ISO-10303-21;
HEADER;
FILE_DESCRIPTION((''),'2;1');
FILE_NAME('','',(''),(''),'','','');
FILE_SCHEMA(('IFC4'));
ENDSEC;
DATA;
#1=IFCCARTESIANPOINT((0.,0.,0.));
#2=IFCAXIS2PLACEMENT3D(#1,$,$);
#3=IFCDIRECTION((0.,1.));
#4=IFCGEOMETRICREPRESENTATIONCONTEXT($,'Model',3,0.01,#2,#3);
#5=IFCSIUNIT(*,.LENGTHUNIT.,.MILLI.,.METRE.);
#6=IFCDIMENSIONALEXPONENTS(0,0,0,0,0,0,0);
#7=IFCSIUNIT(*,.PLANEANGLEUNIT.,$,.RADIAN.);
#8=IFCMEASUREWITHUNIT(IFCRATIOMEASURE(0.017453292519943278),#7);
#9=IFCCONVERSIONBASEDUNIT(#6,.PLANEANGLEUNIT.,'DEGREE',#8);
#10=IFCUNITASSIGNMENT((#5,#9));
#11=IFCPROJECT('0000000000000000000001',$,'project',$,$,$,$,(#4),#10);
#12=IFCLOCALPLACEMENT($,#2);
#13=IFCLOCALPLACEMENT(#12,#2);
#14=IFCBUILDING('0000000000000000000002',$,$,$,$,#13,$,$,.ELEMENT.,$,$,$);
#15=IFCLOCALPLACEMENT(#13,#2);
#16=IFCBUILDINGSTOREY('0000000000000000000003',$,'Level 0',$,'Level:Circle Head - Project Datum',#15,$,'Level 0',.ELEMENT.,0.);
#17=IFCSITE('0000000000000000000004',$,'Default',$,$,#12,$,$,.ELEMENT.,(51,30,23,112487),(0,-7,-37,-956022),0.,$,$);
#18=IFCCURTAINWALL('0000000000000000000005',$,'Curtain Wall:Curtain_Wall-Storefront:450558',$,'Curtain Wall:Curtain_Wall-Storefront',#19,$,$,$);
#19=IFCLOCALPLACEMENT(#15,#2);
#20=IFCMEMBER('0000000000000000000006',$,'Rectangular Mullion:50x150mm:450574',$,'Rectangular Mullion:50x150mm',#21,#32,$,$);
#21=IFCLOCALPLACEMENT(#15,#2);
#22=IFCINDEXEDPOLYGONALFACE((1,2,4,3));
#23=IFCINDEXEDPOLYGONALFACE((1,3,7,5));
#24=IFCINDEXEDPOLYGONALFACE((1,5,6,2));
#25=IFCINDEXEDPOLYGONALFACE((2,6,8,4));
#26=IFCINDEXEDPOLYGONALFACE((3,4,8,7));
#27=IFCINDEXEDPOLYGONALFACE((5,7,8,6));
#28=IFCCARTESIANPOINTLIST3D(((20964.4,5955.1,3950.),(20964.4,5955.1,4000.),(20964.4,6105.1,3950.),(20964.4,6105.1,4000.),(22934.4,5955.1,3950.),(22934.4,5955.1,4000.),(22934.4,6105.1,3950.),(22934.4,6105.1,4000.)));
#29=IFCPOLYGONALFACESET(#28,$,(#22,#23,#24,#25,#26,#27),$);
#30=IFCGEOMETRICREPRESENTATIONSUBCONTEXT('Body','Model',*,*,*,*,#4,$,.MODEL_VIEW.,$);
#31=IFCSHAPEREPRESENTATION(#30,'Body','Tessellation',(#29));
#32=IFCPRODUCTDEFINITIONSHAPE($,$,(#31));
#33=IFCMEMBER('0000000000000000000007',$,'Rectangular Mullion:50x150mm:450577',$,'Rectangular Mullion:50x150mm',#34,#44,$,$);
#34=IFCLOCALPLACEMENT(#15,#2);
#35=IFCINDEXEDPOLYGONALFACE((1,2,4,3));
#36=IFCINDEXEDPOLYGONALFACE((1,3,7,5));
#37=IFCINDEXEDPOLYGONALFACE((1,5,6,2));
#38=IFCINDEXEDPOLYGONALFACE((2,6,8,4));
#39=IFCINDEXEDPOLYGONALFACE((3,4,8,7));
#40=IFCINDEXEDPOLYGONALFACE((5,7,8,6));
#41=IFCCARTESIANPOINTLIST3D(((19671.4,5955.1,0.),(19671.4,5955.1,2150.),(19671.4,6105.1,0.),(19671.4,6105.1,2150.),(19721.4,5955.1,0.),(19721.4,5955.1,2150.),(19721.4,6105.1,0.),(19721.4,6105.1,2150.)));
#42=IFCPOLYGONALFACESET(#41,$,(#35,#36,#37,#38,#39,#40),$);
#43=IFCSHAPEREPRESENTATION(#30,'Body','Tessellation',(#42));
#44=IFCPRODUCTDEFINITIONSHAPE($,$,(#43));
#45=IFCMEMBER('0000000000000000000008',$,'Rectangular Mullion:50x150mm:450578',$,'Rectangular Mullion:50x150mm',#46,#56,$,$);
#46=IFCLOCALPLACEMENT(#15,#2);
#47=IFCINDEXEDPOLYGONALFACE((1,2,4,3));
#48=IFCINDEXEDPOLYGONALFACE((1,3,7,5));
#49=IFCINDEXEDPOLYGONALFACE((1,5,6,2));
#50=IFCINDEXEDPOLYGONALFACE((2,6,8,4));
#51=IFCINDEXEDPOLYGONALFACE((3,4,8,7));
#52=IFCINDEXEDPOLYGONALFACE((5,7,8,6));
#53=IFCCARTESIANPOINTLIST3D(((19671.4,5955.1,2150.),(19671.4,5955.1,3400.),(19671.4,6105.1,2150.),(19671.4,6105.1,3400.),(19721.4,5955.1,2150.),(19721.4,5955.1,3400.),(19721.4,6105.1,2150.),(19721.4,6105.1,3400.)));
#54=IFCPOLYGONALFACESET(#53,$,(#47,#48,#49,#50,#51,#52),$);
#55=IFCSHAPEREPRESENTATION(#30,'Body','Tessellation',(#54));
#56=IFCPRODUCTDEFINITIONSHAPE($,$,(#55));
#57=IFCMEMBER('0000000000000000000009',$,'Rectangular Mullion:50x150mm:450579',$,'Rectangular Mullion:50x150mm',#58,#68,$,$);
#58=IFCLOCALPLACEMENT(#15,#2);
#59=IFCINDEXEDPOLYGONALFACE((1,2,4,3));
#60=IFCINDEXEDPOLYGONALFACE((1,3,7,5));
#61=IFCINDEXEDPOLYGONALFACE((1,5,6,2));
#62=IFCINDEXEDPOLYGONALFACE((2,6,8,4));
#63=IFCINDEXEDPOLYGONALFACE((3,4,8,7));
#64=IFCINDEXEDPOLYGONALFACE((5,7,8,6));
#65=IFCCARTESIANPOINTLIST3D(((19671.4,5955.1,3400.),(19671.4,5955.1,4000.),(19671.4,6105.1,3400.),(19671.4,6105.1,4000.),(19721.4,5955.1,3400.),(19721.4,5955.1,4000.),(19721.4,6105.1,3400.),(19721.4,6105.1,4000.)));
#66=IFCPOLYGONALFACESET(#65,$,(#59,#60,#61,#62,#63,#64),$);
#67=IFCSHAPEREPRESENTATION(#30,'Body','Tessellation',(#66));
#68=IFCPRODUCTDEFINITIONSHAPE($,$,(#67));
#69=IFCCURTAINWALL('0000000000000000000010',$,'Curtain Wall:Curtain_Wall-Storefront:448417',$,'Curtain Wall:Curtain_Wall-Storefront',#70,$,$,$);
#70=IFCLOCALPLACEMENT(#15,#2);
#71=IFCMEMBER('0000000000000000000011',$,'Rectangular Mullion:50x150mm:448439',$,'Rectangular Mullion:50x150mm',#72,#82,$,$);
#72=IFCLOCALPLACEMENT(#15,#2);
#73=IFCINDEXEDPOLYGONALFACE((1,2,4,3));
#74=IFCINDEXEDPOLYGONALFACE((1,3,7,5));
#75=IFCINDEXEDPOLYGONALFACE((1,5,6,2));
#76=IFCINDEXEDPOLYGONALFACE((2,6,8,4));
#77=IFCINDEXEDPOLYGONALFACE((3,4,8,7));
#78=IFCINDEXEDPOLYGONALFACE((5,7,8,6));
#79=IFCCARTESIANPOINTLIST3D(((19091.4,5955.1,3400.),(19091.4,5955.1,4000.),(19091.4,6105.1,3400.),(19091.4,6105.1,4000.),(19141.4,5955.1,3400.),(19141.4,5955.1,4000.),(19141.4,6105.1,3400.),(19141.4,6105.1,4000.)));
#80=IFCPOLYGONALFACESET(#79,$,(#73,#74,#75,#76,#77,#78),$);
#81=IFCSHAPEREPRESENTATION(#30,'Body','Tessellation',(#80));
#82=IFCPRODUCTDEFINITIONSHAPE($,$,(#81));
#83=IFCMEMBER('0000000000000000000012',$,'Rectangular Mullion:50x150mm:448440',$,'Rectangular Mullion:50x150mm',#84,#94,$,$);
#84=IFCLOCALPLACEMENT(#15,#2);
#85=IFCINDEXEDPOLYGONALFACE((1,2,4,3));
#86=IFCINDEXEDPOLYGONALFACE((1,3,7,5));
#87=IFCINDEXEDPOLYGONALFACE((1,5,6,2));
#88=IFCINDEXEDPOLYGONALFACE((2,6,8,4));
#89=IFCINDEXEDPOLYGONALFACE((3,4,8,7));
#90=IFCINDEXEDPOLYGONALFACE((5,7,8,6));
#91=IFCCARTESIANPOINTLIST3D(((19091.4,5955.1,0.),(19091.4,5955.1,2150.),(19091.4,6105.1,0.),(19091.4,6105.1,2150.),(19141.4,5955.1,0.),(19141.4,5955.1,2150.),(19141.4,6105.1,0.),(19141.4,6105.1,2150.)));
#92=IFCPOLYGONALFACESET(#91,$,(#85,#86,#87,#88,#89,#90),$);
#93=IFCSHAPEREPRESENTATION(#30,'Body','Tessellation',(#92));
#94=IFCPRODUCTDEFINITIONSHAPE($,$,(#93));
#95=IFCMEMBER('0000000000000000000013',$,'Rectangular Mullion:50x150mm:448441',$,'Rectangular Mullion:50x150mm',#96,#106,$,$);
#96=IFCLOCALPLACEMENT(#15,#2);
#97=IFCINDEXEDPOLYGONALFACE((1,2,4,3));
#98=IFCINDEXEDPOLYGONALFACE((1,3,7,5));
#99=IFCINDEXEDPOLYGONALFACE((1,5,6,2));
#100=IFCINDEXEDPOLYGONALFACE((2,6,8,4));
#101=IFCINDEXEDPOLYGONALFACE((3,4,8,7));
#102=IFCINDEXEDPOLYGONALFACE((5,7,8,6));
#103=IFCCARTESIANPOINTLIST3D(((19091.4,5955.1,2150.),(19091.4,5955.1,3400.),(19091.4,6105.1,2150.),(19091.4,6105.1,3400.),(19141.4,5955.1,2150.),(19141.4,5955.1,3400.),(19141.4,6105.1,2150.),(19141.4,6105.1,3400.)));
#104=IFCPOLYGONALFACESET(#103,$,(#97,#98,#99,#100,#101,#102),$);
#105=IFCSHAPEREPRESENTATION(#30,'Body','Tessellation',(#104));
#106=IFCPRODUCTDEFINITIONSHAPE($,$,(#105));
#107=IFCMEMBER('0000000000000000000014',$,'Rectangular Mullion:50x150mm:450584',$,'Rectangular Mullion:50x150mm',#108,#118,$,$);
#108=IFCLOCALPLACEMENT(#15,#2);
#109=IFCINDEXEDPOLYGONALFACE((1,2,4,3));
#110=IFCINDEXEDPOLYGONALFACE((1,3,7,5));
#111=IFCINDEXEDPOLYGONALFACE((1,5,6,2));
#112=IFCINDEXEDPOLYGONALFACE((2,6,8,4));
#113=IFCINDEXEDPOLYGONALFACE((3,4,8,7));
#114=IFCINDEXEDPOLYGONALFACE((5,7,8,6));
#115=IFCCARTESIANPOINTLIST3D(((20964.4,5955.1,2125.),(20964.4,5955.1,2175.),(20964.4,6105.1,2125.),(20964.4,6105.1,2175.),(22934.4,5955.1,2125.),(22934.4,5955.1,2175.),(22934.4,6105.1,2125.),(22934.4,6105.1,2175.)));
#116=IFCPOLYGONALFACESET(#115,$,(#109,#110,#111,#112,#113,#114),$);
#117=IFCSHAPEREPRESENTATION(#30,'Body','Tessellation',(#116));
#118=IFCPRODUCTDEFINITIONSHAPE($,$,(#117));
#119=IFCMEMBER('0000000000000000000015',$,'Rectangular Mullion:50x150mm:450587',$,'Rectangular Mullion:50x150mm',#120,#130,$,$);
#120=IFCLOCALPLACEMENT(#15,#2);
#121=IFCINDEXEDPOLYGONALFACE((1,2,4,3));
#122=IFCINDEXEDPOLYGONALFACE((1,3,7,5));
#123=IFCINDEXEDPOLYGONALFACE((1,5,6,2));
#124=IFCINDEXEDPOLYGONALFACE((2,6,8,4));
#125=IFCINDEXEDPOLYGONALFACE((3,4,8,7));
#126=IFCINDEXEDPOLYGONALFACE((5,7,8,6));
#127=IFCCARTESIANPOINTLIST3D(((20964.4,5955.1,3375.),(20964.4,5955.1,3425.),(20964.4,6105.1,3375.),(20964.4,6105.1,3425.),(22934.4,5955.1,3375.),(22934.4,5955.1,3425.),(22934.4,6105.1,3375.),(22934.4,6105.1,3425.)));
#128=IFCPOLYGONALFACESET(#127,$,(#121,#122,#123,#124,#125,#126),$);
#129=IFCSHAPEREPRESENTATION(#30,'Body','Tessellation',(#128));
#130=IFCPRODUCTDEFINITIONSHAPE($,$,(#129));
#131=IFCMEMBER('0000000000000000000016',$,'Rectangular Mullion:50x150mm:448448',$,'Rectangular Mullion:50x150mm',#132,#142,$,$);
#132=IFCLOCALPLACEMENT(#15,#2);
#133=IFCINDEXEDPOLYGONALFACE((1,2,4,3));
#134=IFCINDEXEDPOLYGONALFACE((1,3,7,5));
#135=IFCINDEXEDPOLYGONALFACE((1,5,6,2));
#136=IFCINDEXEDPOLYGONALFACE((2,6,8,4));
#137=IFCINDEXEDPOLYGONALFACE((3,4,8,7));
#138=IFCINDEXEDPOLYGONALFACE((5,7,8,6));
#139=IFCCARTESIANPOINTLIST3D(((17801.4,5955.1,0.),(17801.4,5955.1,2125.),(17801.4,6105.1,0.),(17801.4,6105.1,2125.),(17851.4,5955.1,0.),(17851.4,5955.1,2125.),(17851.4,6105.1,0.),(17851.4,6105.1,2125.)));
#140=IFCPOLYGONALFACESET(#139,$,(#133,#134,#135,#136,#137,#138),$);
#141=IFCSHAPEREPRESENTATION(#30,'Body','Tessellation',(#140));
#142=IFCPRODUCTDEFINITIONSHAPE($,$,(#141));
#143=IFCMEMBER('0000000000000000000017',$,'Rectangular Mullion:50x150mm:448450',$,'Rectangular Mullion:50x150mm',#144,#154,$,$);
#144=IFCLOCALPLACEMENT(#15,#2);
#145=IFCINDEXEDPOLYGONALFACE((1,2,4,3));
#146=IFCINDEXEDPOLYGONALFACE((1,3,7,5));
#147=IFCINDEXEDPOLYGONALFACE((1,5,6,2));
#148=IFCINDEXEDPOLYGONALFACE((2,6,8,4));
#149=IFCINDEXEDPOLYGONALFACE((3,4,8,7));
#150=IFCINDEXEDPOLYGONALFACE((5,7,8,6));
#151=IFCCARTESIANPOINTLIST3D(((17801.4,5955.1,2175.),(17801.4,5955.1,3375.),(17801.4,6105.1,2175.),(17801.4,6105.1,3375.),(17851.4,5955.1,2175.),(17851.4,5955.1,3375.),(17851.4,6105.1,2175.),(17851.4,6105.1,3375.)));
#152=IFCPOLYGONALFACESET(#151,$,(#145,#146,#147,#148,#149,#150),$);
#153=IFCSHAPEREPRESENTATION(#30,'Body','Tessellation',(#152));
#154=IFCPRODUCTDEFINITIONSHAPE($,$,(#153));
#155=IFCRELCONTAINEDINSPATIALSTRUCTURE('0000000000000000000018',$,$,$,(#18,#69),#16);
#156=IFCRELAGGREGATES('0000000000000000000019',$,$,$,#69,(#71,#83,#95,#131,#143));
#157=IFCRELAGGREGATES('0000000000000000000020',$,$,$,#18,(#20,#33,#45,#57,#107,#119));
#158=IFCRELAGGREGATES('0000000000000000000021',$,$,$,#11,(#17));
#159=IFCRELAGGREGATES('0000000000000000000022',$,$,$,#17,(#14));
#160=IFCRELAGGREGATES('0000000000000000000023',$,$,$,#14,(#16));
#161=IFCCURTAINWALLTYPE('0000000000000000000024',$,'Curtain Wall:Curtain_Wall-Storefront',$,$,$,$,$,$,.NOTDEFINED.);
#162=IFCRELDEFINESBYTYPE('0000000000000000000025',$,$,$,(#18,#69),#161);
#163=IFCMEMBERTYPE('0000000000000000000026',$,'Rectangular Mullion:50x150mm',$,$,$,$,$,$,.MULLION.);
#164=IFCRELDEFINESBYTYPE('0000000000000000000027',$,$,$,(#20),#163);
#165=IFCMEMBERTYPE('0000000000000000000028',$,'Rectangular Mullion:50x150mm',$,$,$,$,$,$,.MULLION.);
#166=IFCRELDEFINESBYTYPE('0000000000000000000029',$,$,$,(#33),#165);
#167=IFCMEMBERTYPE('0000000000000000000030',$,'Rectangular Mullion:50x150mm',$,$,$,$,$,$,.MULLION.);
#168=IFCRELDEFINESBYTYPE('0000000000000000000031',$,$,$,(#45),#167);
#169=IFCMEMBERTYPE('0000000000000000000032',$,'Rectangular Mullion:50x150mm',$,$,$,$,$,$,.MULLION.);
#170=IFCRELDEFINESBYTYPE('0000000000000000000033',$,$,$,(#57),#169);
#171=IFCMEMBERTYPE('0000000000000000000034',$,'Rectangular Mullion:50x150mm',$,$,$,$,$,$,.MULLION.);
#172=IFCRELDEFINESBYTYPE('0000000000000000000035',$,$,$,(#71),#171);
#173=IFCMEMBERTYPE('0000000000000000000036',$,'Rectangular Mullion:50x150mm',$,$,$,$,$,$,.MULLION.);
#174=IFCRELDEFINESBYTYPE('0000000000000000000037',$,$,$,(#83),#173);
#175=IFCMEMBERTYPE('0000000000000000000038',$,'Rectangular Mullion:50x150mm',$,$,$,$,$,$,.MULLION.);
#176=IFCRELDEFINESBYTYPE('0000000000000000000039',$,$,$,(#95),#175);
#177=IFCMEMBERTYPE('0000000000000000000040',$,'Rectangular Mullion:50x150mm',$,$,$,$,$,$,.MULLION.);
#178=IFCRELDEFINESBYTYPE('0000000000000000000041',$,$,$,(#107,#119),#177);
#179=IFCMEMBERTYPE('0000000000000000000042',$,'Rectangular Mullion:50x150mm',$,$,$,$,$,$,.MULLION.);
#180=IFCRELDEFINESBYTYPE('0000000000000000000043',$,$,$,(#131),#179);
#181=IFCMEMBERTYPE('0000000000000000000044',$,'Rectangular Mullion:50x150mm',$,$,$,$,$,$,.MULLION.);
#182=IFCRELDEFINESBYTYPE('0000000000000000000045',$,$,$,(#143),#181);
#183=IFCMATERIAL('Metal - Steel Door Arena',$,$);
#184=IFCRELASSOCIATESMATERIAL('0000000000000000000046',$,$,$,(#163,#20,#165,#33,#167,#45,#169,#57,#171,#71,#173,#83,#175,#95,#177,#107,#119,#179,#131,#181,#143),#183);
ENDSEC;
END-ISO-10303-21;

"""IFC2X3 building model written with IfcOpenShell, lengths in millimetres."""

from ifc_helpers import new_model, entity, si_unit, converted_unit, direction, frame, origin, origin_2d_with_axis, place, context, subcontext, project, spatial, rectangle, extrude, source, transform, mapped, material, type_object, type_shapes, element, aggregate, save


model = new_model("IFC2X3")

# Units and contexts
model_context = context("Model", 3, precision=0.01, world=origin(), true_north=direction((0.0, 1.0)))
body_context = subcontext(model_context, "Body", "Model", "MODEL_VIEW")
ifc_project = project(units=[si_unit("LENGTHUNIT", "METRE", prefix="MILLI"), converted_unit("PLANEANGLEUNIT", "DEGREE", entity("IfcRatioMeasure", 0.017453292519943278), si_unit("PLANEANGLEUNIT", "RADIAN"), dimensions=[0, 0, 0, 0, 0, 0, 0])], contexts=[model_context])

# Site, building, storey
site_placement = place(None, origin())
site = spatial("IfcSite", under=ifc_project, at=site_placement, Name="Default", CompositionType="ELEMENT", RefLatitude=(51, 30, 23, 112487), RefLongitude=(0, -7, -37, -956022), RefElevation=0.0)
building_placement = place(site_placement, origin())
building = spatial("IfcBuilding", under=site, at=building_placement, CompositionType="ELEMENT")
storey_placement = place(building_placement, origin())
storey = spatial("IfcBuildingStorey", under=building, at=storey_placement, Name="Level 0", ObjectType="Level:Circle Head - Project Datum", LongName="Level 0", CompositionType="ELEMENT", Elevation=0.0)

# Curtain walls, members
curtain_wall_type = type_object("IfcCurtainWallType", Name="Curtain Wall:Curtain_Wall-Storefront", PredefinedType="NOTDEFINED")
curtain_wall_1_placement = place(storey_placement, origin())
curtain_wall_1 = element("IfcCurtainWall", 1, at=curtain_wall_1_placement, inside=storey, type_object=curtain_wall_type, Name="Curtain Wall:Curtain_Wall-Storefront:450558", ObjectType="Curtain Wall:Curtain_Wall-Storefront")
ifc_material_1 = material(Name="Metal - Steel Door Arena")
member_type_1 = type_object("IfcMemberType", Name="Rectangular Mullion:50x150mm", PredefinedType="MULLION", material=ifc_material_1)
shared_shape_1 = source(origin(), body_context, "Body", "SweptSolid", [
    extrude(rectangle(XDim=150.0, YDim=50.0, at=origin_2d_with_axis()), frame((-25.0, 0.0, -1970.0), z_axis=(0.0, 0.0, 1.0), x_axis=(0.0, -1.0, 0.0)), (0.0, 0.0, 1.0), 1970.0),
])
type_shapes(member_type_1, [shared_shape_1])
member_1_placement = place(curtain_wall_1_placement, frame((20964.4, 6030.1, 4000.0), z_axis=(-1.0, 0.0, 0.0), x_axis=(0.0, 0.0, 1.0)))
member_1 = element("IfcMember", 2, at=member_1_placement, type_object=member_type_1, material=ifc_material_1, Name="Rectangular Mullion:50x150mm:450574", ObjectType="Rectangular Mullion:50x150mm", context=body_context, shape_type="MappedRepresentation", body=[
    mapped(shared_shape_1, transform((0.0, 0.0, 0.0), scale=1.0)),
])
member_type_2 = type_object("IfcMemberType", Name="Rectangular Mullion:50x150mm", PredefinedType="MULLION", material=ifc_material_1)
shared_shape_2 = source(origin(), body_context, "Body", "SweptSolid", [
    extrude(rectangle(XDim=150.0, YDim=50.0, at=origin_2d_with_axis()), frame((-25.0, 0.0, -2150.0), z_axis=(0.0, 0.0, 1.0), x_axis=(0.0, -1.0, 0.0)), (0.0, 0.0, 1.0), 2150.0),
])
type_shapes(member_type_2, [shared_shape_2])
member_2_placement = place(curtain_wall_1_placement, frame((19671.4, 6030.1, 0.0), z_axis=(0.0, 0.0, -1.0), x_axis=(-1.0, 0.0, 0.0)))
member_2 = element("IfcMember", 3, at=member_2_placement, type_object=member_type_2, material=ifc_material_1, Name="Rectangular Mullion:50x150mm:450577", ObjectType="Rectangular Mullion:50x150mm", context=body_context, shape_type="MappedRepresentation", body=[
    mapped(shared_shape_2, transform((0.0, 0.0, 0.0), scale=1.0)),
])
member_type_3 = type_object("IfcMemberType", Name="Rectangular Mullion:50x150mm", PredefinedType="MULLION", material=ifc_material_1)
shared_shape_3 = source(origin(), body_context, "Body", "SweptSolid", [
    extrude(rectangle(XDim=150.0, YDim=50.0, at=origin_2d_with_axis()), frame((-25.0, 0.0, -1250.0), z_axis=(0.0, 0.0, 1.0), x_axis=(0.0, -1.0, 0.0)), (0.0, 0.0, 1.0), 1250.0),
])
type_shapes(member_type_3, [shared_shape_3])
member_3_placement = place(curtain_wall_1_placement, frame((19671.4, 6030.1, 2150.0), z_axis=(0.0, 0.0, -1.0), x_axis=(-1.0, 0.0, 0.0)))
member_3 = element("IfcMember", 4, at=member_3_placement, type_object=member_type_3, material=ifc_material_1, Name="Rectangular Mullion:50x150mm:450578", ObjectType="Rectangular Mullion:50x150mm", context=body_context, shape_type="MappedRepresentation", body=[
    mapped(shared_shape_3, transform((0.0, 0.0, 0.0), scale=1.0)),
])
member_type_4 = type_object("IfcMemberType", Name="Rectangular Mullion:50x150mm", PredefinedType="MULLION", material=ifc_material_1)
shared_shape_4 = source(origin(), body_context, "Body", "SweptSolid", [
    extrude(rectangle(XDim=150.0, YDim=50.0, at=origin_2d_with_axis()), frame((-25.0, 0.0, -600.0), z_axis=(0.0, 0.0, 1.0), x_axis=(0.0, -1.0, 0.0)), (0.0, 0.0, 1.0), 600.0),
])
type_shapes(member_type_4, [shared_shape_4])
member_4_placement = place(curtain_wall_1_placement, frame((19671.4, 6030.1, 3400.0), z_axis=(0.0, 0.0, -1.0), x_axis=(-1.0, 0.0, 0.0)))
member_4 = element("IfcMember", 5, at=member_4_placement, type_object=member_type_4, material=ifc_material_1, Name="Rectangular Mullion:50x150mm:450579", ObjectType="Rectangular Mullion:50x150mm", context=body_context, shape_type="MappedRepresentation", body=[
    mapped(shared_shape_4, transform((0.0, 0.0, 0.0), scale=1.0)),
])
curtain_wall_2_placement = place(storey_placement, origin())
curtain_wall_2 = element("IfcCurtainWall", 6, at=curtain_wall_2_placement, inside=storey, type_object=curtain_wall_type, Name="Curtain Wall:Curtain_Wall-Storefront:448417", ObjectType="Curtain Wall:Curtain_Wall-Storefront")
member_type_5 = type_object("IfcMemberType", Name="Rectangular Mullion:50x150mm", PredefinedType="MULLION", material=ifc_material_1)
shared_shape_5 = source(origin(), body_context, "Body", "SweptSolid", [
    extrude(rectangle(XDim=150.0, YDim=50.0, at=origin_2d_with_axis()), frame((-25.0, 0.0, -600.0), z_axis=(0.0, 0.0, 1.0), x_axis=(0.0, -1.0, 0.0)), (0.0, 0.0, 1.0), 600.0),
])
type_shapes(member_type_5, [shared_shape_5])
member_5_placement = place(curtain_wall_2_placement, frame((19141.4, 6030.1, 4000.0)))
member_5 = element("IfcMember", 7, at=member_5_placement, type_object=member_type_5, material=ifc_material_1, Name="Rectangular Mullion:50x150mm:448439", ObjectType="Rectangular Mullion:50x150mm", context=body_context, shape_type="MappedRepresentation", body=[
    mapped(shared_shape_5, transform((0.0, 0.0, 0.0), scale=1.0)),
])
member_type_6 = type_object("IfcMemberType", Name="Rectangular Mullion:50x150mm", PredefinedType="MULLION", material=ifc_material_1)
shared_shape_6 = source(origin(), body_context, "Body", "SweptSolid", [
    extrude(rectangle(XDim=150.0, YDim=50.0, at=origin_2d_with_axis()), frame((-25.0, 0.0, -2150.0), z_axis=(0.0, 0.0, 1.0), x_axis=(0.0, -1.0, 0.0)), (0.0, 0.0, 1.0), 2150.0),
])
type_shapes(member_type_6, [shared_shape_6])
member_6_placement = place(curtain_wall_2_placement, frame((19141.4, 6030.1, 2150.0)))
member_6 = element("IfcMember", 8, at=member_6_placement, type_object=member_type_6, material=ifc_material_1, Name="Rectangular Mullion:50x150mm:448440", ObjectType="Rectangular Mullion:50x150mm", context=body_context, shape_type="MappedRepresentation", body=[
    mapped(shared_shape_6, transform((0.0, 0.0, 0.0), scale=1.0)),
])
member_type_7 = type_object("IfcMemberType", Name="Rectangular Mullion:50x150mm", PredefinedType="MULLION", material=ifc_material_1)
shared_shape_7 = source(origin(), body_context, "Body", "SweptSolid", [
    extrude(rectangle(XDim=150.0, YDim=50.0, at=origin_2d_with_axis()), frame((-25.0, 0.0, -1250.0), z_axis=(0.0, 0.0, 1.0), x_axis=(0.0, -1.0, 0.0)), (0.0, 0.0, 1.0), 1250.0),
])
type_shapes(member_type_7, [shared_shape_7])
member_7_placement = place(curtain_wall_2_placement, frame((19141.4, 6030.1, 3400.0)))
member_7 = element("IfcMember", 9, at=member_7_placement, type_object=member_type_7, material=ifc_material_1, Name="Rectangular Mullion:50x150mm:448441", ObjectType="Rectangular Mullion:50x150mm", context=body_context, shape_type="MappedRepresentation", body=[
    mapped(shared_shape_7, transform((0.0, 0.0, 0.0), scale=1.0)),
])

# Members
member_type_8 = type_object("IfcMemberType", Name="Rectangular Mullion:50x150mm", PredefinedType="MULLION", material=ifc_material_1)
shared_shape_8 = source(origin(), body_context, "Body", "SweptSolid", [
    extrude(rectangle(XDim=150.0, YDim=50.0, at=origin_2d_with_axis()), frame((0.0, 0.0, -1970.0), z_axis=(0.0, 0.0, 1.0), x_axis=(0.0, -1.0, 0.0)), (0.0, 0.0, 1.0), 1970.0),
])
type_shapes(member_type_8, [shared_shape_8])
member_8_placement = place(curtain_wall_1_placement, frame((20964.4, 6030.1, 2150.0), z_axis=(-1.0, 0.0, 0.0), x_axis=(0.0, 0.0, 1.0)))
member_8 = element("IfcMember", 10, at=member_8_placement, type_object=member_type_8, material=ifc_material_1, Name="Rectangular Mullion:50x150mm:450584", ObjectType="Rectangular Mullion:50x150mm", context=body_context, shape_type="MappedRepresentation", body=[
    mapped(shared_shape_8, transform((0.0, 0.0, 0.0), scale=1.0)),
])
member_9_placement = place(curtain_wall_1_placement, frame((20964.4, 6030.1, 3400.0), z_axis=(-1.0, 0.0, 0.0), x_axis=(0.0, 0.0, 1.0)))
member_9 = element("IfcMember", 11, at=member_9_placement, type_object=member_type_8, material=ifc_material_1, Name="Rectangular Mullion:50x150mm:450587", ObjectType="Rectangular Mullion:50x150mm", context=body_context, shape_type="MappedRepresentation", body=[
    mapped(shared_shape_8, transform((0.0, 0.0, 0.0), scale=1.0)),
])
member_type_9 = type_object("IfcMemberType", Name="Rectangular Mullion:50x150mm", PredefinedType="MULLION", material=ifc_material_1)
shared_shape_9 = source(origin(), body_context, "Body", "SweptSolid", [
    extrude(rectangle(XDim=150.0, YDim=50.0, at=origin_2d_with_axis()), frame((0.0, 0.0, -2125.0), z_axis=(0.0, 0.0, 1.0), x_axis=(0.0, -1.0, 0.0)), (0.0, 0.0, 1.0), 2125.0),
])
type_shapes(member_type_9, [shared_shape_9])
member_10_placement = place(curtain_wall_2_placement, frame((17826.4, 6030.1, 0.0), z_axis=(0.0, 0.0, -1.0), x_axis=(-1.0, 0.0, 0.0)))
member_10 = element("IfcMember", 12, at=member_10_placement, type_object=member_type_9, material=ifc_material_1, Name="Rectangular Mullion:50x150mm:448448", ObjectType="Rectangular Mullion:50x150mm", context=body_context, shape_type="MappedRepresentation", body=[
    mapped(shared_shape_9, transform((0.0, 0.0, 0.0), scale=1.0)),
])
member_type_10 = type_object("IfcMemberType", Name="Rectangular Mullion:50x150mm", PredefinedType="MULLION", material=ifc_material_1)
shared_shape_10 = source(origin(), body_context, "Body", "SweptSolid", [
    extrude(rectangle(XDim=150.0, YDim=50.0, at=origin_2d_with_axis()), frame((0.0, 0.0, -1200.0), z_axis=(0.0, 0.0, 1.0), x_axis=(0.0, -1.0, 0.0)), (0.0, 0.0, 1.0), 1200.0),
])
type_shapes(member_type_10, [shared_shape_10])
member_11_placement = place(curtain_wall_2_placement, frame((17826.4, 6030.1, 2175.0), z_axis=(0.0, 0.0, -1.0), x_axis=(-1.0, 0.0, 0.0)))
member_11 = element("IfcMember", 13, at=member_11_placement, type_object=member_type_10, material=ifc_material_1, Name="Rectangular Mullion:50x150mm:448450", ObjectType="Rectangular Mullion:50x150mm", context=body_context, shape_type="MappedRepresentation", body=[
    mapped(shared_shape_10, transform((0.0, 0.0, 0.0), scale=1.0)),
])

aggregate(curtain_wall_2, [member_5, member_6, member_7, member_10, member_11])
aggregate(curtain_wall_1, [member_1, member_2, member_3, member_4, member_8, member_9])

save(model, "model.ifc")
